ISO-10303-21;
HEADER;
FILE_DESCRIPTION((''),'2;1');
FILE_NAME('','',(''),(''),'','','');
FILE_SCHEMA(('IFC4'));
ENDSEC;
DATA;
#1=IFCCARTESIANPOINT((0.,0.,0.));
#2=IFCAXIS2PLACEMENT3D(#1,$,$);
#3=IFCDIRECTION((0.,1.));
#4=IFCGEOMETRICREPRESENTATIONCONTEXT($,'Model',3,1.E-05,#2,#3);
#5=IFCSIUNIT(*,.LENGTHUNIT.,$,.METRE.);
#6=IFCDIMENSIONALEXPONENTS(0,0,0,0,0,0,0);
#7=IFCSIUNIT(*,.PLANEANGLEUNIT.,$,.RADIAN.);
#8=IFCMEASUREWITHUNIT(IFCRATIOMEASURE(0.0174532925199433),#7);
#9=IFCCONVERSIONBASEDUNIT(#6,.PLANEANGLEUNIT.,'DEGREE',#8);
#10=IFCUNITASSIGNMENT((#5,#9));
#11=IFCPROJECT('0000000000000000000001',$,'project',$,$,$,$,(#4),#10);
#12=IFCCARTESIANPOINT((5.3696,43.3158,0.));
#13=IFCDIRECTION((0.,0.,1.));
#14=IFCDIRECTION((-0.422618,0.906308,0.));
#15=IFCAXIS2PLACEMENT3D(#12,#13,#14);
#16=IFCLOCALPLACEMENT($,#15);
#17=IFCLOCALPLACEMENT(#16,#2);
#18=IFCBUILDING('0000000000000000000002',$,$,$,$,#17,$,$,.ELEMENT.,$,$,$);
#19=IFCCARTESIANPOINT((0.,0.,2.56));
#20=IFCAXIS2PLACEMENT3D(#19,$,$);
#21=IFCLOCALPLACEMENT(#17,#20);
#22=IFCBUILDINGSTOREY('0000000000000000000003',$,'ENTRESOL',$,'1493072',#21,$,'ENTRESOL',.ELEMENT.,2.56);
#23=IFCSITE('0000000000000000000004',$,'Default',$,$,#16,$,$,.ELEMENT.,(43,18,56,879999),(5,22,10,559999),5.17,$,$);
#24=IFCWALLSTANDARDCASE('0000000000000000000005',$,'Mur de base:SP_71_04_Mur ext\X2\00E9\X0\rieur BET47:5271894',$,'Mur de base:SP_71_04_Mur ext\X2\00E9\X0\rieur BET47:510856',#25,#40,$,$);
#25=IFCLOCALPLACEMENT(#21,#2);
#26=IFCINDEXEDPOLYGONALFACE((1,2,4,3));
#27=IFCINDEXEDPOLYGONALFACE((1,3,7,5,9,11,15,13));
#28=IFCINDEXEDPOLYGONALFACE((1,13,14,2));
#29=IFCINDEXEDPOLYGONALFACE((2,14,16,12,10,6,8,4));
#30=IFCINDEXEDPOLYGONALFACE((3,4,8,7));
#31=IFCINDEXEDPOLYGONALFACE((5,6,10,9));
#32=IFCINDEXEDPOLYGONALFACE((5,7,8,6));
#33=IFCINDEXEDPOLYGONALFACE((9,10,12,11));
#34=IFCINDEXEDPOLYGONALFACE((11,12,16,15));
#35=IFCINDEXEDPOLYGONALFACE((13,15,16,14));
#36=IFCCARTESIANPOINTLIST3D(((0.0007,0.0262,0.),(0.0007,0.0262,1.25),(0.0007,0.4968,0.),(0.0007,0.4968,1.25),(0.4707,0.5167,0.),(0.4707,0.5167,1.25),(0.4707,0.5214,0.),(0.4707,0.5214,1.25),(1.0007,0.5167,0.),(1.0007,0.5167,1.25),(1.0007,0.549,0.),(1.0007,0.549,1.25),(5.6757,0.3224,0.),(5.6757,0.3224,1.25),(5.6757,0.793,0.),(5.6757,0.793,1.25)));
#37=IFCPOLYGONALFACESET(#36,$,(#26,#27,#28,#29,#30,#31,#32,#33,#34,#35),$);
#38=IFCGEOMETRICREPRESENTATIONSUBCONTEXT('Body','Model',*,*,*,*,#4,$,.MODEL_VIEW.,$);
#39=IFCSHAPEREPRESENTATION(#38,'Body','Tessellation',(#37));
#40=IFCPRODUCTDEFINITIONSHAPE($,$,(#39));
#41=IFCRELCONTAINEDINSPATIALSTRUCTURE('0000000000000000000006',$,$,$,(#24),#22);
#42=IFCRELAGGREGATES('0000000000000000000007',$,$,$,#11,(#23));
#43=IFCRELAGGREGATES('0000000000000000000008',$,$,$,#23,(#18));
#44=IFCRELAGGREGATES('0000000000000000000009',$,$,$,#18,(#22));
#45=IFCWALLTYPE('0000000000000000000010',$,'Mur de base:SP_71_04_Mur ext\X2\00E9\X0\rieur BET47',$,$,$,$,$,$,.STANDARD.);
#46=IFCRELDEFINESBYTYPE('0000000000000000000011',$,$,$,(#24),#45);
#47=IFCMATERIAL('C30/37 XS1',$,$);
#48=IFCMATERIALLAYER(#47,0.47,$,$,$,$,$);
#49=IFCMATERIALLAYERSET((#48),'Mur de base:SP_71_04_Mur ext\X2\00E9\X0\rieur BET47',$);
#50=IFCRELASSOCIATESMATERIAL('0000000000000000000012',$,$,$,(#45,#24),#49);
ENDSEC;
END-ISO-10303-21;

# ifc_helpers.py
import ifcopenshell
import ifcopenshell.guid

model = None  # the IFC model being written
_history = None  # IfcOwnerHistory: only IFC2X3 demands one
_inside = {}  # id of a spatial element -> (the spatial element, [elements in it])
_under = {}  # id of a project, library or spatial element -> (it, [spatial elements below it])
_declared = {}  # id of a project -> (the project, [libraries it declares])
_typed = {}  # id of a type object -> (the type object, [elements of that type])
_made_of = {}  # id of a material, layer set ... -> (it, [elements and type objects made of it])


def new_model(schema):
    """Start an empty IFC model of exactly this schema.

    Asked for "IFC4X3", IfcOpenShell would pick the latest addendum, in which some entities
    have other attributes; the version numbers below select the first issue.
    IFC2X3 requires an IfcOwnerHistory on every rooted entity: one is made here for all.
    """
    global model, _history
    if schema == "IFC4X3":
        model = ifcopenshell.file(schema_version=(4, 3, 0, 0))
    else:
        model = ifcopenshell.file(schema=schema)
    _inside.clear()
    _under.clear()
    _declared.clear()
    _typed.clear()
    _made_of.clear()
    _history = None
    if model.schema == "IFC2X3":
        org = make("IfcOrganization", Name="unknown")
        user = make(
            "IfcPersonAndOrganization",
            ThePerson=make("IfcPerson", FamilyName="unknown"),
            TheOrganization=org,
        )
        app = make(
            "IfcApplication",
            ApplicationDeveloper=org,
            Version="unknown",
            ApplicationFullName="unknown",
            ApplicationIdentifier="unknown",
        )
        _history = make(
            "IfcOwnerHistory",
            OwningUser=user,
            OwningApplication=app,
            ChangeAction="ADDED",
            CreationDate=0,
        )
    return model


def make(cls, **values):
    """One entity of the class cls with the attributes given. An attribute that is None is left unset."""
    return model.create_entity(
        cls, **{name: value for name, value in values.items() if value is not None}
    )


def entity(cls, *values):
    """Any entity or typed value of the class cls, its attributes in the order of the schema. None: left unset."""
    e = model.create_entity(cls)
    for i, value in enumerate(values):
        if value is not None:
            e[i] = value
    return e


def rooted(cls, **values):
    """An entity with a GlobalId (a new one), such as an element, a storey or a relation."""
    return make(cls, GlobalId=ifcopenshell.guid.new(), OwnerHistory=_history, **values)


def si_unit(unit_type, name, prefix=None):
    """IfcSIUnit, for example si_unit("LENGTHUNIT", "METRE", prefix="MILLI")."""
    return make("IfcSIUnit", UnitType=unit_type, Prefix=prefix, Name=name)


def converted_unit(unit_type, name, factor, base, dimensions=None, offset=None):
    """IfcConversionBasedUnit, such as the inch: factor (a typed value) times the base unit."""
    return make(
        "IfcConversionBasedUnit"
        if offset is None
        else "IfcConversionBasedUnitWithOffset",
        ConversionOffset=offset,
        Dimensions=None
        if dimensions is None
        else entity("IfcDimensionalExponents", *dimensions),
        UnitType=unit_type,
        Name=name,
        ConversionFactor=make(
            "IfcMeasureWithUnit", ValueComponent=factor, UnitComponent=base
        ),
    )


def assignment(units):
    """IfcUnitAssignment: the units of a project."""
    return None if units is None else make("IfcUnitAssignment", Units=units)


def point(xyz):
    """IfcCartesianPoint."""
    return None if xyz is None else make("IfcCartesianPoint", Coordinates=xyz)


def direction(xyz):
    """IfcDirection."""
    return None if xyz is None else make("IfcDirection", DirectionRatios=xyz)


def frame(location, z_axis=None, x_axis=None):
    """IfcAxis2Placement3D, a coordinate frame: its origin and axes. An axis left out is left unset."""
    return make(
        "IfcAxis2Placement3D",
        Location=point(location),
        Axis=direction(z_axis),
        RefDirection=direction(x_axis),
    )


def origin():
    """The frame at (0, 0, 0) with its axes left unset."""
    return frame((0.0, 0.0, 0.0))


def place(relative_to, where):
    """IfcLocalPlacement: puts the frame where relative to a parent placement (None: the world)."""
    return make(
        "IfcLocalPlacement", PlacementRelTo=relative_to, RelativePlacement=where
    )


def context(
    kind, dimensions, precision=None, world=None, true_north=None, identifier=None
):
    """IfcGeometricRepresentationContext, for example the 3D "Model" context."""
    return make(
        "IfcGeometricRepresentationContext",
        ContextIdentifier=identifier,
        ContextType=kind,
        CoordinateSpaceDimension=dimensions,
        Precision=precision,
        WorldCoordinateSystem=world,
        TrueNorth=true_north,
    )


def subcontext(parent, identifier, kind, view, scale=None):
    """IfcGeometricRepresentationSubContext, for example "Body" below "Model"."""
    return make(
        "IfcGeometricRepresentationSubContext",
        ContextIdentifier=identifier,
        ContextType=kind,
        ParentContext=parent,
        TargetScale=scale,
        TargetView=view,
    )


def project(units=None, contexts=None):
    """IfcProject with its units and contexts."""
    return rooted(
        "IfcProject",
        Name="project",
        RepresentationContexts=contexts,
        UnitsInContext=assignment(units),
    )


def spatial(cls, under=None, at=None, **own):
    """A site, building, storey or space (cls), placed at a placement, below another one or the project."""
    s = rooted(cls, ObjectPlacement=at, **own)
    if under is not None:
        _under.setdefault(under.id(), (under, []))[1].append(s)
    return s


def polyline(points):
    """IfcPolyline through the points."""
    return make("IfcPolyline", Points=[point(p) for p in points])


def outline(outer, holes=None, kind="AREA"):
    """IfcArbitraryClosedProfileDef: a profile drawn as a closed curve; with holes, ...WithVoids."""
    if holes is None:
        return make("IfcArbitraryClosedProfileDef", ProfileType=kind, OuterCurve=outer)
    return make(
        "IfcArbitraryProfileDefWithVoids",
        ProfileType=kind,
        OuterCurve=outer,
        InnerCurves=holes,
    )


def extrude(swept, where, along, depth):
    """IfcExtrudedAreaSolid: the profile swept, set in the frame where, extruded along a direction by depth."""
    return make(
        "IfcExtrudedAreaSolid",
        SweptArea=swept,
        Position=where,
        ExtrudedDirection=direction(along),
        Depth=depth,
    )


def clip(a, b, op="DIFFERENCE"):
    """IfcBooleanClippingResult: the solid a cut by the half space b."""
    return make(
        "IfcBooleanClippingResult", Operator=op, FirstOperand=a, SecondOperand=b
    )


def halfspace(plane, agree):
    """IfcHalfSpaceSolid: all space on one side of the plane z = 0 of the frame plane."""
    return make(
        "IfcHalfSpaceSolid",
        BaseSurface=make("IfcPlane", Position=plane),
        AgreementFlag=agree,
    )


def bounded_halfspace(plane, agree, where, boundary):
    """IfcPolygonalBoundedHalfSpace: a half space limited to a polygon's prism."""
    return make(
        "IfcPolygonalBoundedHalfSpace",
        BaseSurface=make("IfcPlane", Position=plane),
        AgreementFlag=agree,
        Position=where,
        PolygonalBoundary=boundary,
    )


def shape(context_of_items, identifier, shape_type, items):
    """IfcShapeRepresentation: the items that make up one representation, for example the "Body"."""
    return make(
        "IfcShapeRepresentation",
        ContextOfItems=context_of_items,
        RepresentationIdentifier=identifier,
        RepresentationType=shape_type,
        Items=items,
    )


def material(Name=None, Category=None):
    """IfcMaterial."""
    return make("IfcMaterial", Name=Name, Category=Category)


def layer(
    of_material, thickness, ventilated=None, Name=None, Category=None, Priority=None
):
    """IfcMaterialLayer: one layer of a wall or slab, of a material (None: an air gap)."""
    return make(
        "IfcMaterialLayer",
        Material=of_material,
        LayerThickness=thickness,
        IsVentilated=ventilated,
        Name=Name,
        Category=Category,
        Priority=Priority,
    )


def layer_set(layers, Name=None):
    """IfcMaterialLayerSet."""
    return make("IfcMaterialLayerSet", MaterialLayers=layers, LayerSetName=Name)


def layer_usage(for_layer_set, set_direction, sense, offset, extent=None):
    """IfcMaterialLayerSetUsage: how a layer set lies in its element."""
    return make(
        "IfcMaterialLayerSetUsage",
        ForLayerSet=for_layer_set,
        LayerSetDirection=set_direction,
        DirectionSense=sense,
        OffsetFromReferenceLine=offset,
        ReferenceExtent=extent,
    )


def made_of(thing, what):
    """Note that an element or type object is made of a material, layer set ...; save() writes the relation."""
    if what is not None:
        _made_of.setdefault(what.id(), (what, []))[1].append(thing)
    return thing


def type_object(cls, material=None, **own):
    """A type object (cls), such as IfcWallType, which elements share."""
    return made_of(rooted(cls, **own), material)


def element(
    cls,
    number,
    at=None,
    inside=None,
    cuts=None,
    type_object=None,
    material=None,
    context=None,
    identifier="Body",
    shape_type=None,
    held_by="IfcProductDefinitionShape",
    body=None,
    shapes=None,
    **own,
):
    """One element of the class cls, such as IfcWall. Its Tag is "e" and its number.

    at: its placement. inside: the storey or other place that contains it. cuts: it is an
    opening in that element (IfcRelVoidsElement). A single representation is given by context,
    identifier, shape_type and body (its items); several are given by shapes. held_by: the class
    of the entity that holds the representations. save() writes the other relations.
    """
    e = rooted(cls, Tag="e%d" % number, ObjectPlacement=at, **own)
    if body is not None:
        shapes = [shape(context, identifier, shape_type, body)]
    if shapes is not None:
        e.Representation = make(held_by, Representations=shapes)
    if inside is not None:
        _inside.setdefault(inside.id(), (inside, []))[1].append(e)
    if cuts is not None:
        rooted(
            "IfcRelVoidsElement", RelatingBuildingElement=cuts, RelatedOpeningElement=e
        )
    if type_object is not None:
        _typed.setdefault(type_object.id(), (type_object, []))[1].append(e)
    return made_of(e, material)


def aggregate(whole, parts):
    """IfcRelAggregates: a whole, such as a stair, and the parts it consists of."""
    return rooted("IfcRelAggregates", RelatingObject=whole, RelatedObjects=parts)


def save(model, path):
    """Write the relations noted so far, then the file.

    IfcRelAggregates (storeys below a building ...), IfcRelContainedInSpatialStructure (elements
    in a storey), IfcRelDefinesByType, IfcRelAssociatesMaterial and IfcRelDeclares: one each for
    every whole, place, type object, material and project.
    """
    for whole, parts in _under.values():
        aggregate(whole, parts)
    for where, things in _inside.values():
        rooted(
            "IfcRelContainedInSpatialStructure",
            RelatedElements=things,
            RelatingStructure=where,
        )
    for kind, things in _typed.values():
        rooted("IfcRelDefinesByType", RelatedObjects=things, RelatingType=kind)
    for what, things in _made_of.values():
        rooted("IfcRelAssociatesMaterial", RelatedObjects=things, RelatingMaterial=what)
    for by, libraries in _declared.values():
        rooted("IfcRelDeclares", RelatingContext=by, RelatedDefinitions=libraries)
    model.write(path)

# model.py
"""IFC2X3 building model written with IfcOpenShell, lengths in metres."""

from ifc_helpers import new_model, entity, si_unit, converted_unit, direction, frame, origin, place, context, subcontext, project, spatial, polyline, outline, extrude, clip, halfspace, bounded_halfspace, material, layer, layer_set, layer_usage, type_object, element, save


model = new_model("IFC2X3")

# Units and contexts
model_context = context("Model", 3, precision=1e-05, world=origin(), true_north=direction((0.0, 1.0)))
body_context = subcontext(model_context, "Body", "Model", "MODEL_VIEW")
ifc_project = project(units=[si_unit("LENGTHUNIT", "METRE"), converted_unit("PLANEANGLEUNIT", "DEGREE", entity("IfcRatioMeasure", 0.0174532925199433), si_unit("PLANEANGLEUNIT", "RADIAN"), dimensions=[0, 0, 0, 0, 0, 0, 0])], contexts=[model_context])

# Site, building, storey
site_placement = place(None, frame((5.3696, 43.3158, 0.0), z_axis=(0.0, 0.0, 1.0), x_axis=(-0.422618, 0.906308, 0.0)))
site = spatial("IfcSite", under=ifc_project, at=site_placement, Name="Default", CompositionType="ELEMENT", RefLatitude=(43, 18, 56, 879999), RefLongitude=(5, 22, 10, 559999), RefElevation=5.17)
building_placement = place(site_placement, origin())
building = spatial("IfcBuilding", under=site, at=building_placement, CompositionType="ELEMENT")
storey_placement = place(building_placement, frame((0.0, 0.0, 2.56)))
storey = spatial("IfcBuildingStorey", under=building, at=storey_placement, Name="ENTRESOL", ObjectType="1493072", LongName="ENTRESOL", CompositionType="ELEMENT", Elevation=2.56)

# Shared definitions
ifc_material_1 = material(Name="C30/37 XS1")

# Wall
ifc_layer_1 = layer(ifc_material_1, 0.47)
ifc_layer_set_1 = layer_set([ifc_layer_1], Name="Mur de base:SP_71_04_Mur extérieur BET47")
wall_type_1 = type_object("IfcWallType", Name="Mur de base:SP_71_04_Mur extérieur BET47", PredefinedType="STANDARD", material=ifc_layer_set_1)
ifc_layer_usage_1 = layer_usage(ifc_layer_set_1, "AXIS2", "NEGATIVE", 0.235)
wall_1_placement = place(storey_placement, frame((5.6879, 0.5583, 0.0), z_axis=(0.0, 0.0, 1.0), x_axis=(-0.998641, -0.05212, 0.0)))
element("IfcWallStandardCase", 1, at=wall_1_placement, inside=storey, type_object=wall_type_1, material=ifc_layer_usage_1, Name="Mur de base:SP_71_04_Mur extérieur BET47:5271894", ObjectType="Mur de base:SP_71_04_Mur extérieur BET47:510856", context=body_context, shape_type="Clipping", body=[
    clip(clip(extrude(outline(polyline([(5.6827, -0.235), (5.7073, 0.235), (0.0245, 0.235), (0.0, -0.235), (5.2121, -0.235), (5.6827, -0.235)])), origin(), (0.0, 0.0, 1.0), 1.25), bounded_halfspace(frame((5.2123, -0.2303, -0.2), z_axis=(0.05212, 0.998641, 0.0), x_axis=(0.998641, -0.05212, 0.0)), True, frame((5.2123, -0.2303, -0.2), z_axis=(0.05212, 0.998641, 0.0), x_axis=(0.998641, -0.05212, 0.0)), polyline([(0.0, 0.0), (-0.53, 0.0), (-0.53, -1.45), (0.0, -1.45), (0.0, 0.0)]))), halfspace(frame((0.0, 0.0, -2.56)), True)),
])

save(model, "model.ifc")
